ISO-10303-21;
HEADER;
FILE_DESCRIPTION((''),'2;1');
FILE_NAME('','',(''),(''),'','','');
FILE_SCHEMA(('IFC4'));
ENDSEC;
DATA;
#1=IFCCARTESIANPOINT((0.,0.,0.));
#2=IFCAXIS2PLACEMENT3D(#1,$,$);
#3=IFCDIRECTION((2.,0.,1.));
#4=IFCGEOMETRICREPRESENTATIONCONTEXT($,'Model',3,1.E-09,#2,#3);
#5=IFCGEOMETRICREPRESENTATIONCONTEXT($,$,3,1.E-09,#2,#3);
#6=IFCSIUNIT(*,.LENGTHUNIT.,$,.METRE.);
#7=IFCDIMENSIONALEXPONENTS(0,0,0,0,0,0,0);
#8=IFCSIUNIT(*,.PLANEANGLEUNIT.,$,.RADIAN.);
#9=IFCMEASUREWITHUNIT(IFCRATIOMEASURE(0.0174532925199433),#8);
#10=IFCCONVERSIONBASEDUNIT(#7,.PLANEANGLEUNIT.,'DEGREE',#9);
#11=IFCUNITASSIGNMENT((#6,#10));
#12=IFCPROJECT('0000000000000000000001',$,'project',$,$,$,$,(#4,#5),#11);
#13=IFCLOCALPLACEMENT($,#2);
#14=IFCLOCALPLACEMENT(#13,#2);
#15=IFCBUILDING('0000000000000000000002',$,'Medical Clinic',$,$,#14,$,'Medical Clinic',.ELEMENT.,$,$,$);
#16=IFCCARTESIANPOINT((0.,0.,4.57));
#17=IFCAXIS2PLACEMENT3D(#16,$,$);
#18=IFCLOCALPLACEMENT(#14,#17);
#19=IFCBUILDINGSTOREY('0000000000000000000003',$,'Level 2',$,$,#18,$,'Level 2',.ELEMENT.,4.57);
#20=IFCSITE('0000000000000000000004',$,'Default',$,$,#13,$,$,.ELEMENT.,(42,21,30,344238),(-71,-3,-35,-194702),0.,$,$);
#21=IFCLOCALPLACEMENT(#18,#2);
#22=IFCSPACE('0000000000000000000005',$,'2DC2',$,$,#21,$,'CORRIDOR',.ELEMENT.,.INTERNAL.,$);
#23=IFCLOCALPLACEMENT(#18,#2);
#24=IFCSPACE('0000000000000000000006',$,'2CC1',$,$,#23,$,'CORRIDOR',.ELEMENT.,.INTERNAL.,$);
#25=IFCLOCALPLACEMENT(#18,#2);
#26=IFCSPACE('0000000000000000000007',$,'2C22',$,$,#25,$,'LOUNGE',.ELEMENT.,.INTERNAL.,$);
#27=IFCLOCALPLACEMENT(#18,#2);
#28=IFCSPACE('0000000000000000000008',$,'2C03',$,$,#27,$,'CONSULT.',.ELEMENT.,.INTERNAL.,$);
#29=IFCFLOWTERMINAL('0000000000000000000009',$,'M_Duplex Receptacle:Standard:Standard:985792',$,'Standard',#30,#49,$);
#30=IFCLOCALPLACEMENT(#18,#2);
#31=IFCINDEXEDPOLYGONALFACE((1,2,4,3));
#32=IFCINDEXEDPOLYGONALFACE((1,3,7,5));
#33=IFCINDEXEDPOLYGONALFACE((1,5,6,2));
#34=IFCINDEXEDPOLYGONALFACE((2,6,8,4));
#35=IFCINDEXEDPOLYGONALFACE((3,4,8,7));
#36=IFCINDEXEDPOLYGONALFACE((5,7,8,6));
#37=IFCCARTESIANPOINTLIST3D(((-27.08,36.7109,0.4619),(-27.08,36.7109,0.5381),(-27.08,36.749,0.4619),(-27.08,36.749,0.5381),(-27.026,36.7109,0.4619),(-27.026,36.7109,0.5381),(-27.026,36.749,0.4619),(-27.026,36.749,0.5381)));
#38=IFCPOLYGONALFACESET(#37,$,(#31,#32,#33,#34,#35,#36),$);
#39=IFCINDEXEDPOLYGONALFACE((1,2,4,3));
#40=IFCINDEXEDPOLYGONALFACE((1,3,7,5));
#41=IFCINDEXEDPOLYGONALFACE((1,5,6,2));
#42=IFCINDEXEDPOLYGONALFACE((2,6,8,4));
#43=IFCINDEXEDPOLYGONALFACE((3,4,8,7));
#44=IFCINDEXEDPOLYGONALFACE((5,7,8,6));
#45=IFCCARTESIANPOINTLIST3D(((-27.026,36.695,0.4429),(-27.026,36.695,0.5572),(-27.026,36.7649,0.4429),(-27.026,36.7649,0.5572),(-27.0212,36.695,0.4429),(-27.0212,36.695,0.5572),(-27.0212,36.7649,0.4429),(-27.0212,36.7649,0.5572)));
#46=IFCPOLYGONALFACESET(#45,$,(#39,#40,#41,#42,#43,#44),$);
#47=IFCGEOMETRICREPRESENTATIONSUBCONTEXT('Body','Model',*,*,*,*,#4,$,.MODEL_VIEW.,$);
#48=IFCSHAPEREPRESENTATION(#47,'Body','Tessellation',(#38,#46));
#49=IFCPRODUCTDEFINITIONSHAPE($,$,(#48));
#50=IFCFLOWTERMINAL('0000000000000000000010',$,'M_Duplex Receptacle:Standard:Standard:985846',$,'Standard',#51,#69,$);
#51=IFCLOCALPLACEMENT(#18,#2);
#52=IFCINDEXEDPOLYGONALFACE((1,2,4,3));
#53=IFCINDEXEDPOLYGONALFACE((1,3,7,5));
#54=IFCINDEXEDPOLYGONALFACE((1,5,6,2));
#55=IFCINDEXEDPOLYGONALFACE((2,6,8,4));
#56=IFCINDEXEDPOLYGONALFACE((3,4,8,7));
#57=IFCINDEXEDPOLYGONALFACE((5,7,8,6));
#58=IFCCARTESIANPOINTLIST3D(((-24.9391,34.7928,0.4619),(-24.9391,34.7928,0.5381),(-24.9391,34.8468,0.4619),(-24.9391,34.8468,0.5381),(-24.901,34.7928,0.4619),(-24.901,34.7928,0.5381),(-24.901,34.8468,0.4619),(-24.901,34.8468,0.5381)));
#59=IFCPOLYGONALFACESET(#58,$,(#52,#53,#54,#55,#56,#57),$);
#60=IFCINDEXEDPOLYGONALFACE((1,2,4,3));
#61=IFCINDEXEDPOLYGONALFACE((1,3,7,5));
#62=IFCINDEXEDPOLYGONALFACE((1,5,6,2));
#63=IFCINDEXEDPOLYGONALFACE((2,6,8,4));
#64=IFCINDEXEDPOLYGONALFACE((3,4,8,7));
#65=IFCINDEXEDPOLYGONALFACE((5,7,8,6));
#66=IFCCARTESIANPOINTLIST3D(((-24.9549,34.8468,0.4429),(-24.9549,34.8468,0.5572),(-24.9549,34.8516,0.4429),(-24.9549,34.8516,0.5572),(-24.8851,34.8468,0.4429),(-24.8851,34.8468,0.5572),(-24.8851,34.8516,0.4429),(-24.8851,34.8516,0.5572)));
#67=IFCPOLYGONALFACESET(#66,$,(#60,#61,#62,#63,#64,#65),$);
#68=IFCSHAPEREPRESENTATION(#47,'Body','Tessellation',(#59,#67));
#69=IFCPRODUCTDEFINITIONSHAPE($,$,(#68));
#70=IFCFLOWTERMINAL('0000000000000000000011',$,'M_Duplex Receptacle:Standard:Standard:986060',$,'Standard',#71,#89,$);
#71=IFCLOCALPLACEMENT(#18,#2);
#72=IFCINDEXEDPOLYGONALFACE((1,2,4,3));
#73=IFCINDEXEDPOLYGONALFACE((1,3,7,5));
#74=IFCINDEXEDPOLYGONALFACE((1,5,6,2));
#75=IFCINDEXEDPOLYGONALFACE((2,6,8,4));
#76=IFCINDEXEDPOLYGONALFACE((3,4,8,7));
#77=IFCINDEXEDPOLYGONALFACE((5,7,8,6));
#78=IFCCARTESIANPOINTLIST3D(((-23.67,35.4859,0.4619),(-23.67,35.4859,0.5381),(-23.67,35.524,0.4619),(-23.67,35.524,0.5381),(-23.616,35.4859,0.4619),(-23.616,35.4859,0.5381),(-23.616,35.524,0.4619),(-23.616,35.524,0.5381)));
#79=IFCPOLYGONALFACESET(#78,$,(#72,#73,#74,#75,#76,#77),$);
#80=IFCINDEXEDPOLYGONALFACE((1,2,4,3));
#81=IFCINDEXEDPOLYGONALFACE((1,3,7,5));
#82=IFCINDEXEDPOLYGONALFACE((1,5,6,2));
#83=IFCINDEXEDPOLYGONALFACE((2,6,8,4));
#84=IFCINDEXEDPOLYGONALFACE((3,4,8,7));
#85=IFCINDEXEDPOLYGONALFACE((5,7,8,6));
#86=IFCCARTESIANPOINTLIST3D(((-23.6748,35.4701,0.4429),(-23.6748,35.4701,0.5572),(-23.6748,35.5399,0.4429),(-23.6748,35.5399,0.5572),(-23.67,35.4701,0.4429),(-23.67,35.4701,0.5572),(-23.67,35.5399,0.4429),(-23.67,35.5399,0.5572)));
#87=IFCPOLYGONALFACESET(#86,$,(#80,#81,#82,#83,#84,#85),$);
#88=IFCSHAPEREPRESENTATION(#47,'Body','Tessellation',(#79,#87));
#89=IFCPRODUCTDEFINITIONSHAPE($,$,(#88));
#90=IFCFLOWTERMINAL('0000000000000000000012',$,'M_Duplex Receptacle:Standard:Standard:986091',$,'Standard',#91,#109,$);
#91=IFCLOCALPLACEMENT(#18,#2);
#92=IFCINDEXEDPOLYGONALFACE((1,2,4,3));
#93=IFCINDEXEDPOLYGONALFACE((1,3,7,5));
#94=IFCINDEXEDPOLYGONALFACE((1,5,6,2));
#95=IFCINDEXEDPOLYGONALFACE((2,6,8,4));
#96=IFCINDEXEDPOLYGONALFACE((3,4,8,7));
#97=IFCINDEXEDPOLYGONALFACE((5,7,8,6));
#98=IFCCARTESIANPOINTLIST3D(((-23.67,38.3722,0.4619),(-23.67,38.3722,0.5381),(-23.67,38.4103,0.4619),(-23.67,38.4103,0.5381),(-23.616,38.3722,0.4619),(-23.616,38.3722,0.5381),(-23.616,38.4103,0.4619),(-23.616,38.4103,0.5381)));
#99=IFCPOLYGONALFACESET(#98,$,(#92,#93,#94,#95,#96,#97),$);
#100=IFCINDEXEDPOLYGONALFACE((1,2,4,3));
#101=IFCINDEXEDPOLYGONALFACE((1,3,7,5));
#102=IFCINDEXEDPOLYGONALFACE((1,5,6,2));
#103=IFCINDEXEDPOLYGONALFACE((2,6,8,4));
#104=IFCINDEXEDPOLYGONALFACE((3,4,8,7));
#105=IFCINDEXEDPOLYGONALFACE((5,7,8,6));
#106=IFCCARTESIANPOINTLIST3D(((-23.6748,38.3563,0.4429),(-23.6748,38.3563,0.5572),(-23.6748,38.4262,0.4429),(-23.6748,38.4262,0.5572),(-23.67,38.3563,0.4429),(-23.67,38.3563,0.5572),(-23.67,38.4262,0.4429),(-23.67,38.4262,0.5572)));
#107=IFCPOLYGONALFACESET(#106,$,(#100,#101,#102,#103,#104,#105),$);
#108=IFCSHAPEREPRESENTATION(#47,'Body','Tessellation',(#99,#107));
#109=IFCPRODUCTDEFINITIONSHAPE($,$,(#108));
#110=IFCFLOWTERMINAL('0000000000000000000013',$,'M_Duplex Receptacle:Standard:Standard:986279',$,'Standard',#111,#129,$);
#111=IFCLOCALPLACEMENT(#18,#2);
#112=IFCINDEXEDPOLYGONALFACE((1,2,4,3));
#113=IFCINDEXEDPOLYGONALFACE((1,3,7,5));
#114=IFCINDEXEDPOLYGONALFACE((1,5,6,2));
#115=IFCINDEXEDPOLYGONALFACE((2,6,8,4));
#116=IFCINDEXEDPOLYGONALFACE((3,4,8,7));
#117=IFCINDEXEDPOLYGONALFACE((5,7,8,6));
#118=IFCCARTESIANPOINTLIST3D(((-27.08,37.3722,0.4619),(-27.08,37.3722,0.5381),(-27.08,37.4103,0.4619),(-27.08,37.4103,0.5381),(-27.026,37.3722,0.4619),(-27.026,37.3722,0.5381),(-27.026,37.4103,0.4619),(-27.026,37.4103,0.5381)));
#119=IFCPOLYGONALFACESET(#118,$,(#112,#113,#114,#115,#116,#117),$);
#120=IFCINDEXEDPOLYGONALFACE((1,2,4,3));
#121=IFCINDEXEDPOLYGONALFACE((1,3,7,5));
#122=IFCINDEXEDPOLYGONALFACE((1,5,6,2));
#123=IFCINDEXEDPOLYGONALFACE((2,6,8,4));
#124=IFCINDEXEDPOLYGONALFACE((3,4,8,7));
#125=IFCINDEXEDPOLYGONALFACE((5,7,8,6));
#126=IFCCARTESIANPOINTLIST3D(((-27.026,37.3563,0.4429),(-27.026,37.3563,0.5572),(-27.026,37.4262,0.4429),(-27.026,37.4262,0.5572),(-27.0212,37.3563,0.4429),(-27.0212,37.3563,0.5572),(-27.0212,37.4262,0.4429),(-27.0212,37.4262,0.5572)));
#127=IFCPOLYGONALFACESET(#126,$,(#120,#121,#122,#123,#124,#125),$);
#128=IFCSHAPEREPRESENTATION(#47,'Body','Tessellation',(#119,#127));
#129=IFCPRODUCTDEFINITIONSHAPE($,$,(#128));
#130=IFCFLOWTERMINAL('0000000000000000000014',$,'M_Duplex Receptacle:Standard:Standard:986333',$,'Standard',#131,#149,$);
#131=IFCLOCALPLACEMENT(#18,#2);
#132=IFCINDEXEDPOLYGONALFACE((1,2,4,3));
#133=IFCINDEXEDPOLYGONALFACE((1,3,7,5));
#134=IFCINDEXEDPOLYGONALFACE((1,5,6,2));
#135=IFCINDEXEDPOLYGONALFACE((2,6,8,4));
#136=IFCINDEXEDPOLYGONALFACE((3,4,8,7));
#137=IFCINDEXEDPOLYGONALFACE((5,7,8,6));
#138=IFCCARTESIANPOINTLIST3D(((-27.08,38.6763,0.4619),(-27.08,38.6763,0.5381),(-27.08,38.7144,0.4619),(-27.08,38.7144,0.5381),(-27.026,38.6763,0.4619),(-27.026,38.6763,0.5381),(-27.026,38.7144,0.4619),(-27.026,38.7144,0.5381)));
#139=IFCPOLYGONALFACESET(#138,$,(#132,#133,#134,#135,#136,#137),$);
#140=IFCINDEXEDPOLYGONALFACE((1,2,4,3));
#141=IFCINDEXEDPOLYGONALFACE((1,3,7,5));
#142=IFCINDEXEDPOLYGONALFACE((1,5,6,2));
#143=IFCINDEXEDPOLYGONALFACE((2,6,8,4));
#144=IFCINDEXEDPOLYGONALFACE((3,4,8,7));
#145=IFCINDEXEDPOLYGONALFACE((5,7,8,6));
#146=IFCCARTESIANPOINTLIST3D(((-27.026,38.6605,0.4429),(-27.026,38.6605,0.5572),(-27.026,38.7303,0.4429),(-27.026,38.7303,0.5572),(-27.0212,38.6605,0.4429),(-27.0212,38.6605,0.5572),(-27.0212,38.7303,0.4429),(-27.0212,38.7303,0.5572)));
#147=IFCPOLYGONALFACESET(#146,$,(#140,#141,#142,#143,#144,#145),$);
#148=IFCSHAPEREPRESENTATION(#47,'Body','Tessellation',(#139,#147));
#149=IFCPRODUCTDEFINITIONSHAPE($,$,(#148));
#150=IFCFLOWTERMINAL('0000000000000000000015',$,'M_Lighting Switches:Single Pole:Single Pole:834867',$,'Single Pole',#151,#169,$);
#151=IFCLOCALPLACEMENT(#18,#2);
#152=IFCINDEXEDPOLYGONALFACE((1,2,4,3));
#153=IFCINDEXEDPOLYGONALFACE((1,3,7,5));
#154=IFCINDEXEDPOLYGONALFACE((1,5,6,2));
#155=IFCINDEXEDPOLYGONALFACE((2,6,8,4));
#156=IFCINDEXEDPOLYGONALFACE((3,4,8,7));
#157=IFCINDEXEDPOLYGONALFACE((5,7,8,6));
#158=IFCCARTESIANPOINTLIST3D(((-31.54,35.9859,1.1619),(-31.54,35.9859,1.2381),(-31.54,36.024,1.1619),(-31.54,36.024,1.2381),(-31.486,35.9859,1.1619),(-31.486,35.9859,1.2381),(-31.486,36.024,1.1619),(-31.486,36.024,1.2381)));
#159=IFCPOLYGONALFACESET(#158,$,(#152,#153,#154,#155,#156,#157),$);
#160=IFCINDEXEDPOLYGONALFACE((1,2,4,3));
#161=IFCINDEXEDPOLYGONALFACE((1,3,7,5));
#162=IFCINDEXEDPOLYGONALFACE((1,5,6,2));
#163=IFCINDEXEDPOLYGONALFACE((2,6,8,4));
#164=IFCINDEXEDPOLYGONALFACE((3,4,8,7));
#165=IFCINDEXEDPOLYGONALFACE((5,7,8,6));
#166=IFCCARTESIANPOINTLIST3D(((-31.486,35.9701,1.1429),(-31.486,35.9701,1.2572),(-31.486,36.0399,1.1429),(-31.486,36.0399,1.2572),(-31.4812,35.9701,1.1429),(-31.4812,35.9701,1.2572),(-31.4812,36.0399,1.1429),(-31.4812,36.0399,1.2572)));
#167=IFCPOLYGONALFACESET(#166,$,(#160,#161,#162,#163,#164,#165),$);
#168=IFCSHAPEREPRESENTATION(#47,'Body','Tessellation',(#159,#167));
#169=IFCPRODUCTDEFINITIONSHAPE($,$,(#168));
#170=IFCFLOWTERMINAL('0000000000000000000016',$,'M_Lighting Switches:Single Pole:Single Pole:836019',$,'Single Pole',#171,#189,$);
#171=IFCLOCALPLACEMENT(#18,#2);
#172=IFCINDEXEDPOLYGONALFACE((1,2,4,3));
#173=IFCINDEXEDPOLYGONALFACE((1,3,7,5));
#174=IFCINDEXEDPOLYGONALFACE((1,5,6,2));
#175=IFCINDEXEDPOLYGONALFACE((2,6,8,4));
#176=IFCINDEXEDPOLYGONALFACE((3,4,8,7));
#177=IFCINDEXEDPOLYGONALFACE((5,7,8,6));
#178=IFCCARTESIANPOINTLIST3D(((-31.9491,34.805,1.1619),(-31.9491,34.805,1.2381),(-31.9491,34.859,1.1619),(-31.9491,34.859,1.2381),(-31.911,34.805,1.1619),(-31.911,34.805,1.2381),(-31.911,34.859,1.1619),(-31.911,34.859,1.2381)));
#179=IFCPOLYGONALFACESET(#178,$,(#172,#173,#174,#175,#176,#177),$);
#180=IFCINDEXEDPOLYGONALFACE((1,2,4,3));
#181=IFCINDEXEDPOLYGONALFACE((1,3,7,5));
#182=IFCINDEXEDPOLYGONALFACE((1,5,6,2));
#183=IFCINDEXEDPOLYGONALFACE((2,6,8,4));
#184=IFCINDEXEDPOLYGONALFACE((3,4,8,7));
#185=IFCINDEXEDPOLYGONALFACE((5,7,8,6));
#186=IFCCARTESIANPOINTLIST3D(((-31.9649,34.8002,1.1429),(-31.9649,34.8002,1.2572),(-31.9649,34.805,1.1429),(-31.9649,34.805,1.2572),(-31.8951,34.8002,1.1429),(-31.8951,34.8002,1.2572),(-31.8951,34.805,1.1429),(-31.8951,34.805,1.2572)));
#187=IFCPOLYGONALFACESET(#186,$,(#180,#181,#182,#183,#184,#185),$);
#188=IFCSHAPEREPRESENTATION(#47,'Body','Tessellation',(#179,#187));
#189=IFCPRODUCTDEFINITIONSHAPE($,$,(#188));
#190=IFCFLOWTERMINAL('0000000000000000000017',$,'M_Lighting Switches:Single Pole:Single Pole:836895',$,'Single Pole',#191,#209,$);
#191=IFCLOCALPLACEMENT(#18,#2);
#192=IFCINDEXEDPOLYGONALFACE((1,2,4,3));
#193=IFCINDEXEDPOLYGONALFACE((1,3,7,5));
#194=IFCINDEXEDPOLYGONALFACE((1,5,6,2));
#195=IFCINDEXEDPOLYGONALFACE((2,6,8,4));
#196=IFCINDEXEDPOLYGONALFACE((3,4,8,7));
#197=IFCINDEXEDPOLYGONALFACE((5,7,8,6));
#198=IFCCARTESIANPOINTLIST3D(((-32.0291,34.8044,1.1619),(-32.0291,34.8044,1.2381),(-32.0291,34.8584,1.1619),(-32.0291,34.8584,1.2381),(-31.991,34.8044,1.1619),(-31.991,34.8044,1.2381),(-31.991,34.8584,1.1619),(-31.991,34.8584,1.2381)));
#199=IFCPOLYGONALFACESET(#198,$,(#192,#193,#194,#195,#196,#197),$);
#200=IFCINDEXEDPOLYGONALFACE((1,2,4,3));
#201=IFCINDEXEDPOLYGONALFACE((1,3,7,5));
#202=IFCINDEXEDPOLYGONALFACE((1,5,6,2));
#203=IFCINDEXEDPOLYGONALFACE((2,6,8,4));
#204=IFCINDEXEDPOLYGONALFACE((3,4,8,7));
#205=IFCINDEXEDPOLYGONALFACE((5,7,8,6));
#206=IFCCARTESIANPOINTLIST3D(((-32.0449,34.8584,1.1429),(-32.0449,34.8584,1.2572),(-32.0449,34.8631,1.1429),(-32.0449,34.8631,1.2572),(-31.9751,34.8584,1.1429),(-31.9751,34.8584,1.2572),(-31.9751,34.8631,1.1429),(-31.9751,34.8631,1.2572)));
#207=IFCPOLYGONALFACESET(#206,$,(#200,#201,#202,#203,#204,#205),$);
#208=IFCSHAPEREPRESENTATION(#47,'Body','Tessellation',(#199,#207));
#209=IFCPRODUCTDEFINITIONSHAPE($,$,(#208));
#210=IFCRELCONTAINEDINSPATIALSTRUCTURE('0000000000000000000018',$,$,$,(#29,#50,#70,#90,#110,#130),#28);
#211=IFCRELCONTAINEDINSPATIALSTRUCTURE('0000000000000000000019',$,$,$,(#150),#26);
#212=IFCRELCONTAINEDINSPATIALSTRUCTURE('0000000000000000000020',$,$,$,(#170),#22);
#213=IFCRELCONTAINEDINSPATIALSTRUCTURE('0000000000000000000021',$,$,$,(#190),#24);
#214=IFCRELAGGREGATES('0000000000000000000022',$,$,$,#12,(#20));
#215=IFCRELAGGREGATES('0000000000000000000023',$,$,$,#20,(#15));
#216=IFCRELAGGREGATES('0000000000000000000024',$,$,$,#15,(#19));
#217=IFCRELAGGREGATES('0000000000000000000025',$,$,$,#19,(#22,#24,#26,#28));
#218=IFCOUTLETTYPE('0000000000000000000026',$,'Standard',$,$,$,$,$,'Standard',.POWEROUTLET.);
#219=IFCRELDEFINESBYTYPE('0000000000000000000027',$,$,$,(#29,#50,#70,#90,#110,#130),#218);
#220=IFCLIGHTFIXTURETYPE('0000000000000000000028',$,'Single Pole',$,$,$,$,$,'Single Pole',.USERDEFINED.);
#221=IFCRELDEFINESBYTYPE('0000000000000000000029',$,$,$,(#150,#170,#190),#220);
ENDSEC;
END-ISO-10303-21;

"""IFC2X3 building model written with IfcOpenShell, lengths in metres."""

from ifc_helpers import new_model, entity, si_unit, converted_unit, direction, frame, frame_2d, origin, origin_2d_with_axis, place, context, subcontext, project, spatial, rectangle, extrude, source, transform, mapped, type_object, type_shapes, element, save


model = new_model("IFC2X3")

# Units and contexts
model_context = context("Model", 3, precision=1e-09, world=origin(), true_north=direction((2.0, 0.0, 1.0)))
context_of_model = context(None, 3, precision=1e-09, world=origin(), true_north=direction((2.0, 0.0, 1.0)))
body_context = subcontext(model_context, "Body", "Model", "MODEL_VIEW")
ifc_project = project(units=[si_unit("LENGTHUNIT", "METRE"), converted_unit("PLANEANGLEUNIT", "DEGREE", entity("IfcRatioMeasure", 0.0174532925199433), si_unit("PLANEANGLEUNIT", "RADIAN"), dimensions=[0, 0, 0, 0, 0, 0, 0])], contexts=[model_context, context_of_model])

# Site, building, storey, space
site_placement = place(None, origin())
site = spatial("IfcSite", under=ifc_project, at=site_placement, Name="Default", CompositionType="ELEMENT", RefLatitude=(42, 21, 30, 344238), RefLongitude=(-71, -3, -35, -194702), RefElevation=0.0)
building_placement = place(site_placement, origin())
building = spatial("IfcBuilding", under=site, at=building_placement, Name="Medical Clinic", LongName="Medical Clinic", CompositionType="ELEMENT")
storey_placement = place(building_placement, frame((0.0, 0.0, 4.57)))
storey = spatial("IfcBuildingStorey", under=building, at=storey_placement, Name="Level 2", LongName="Level 2", CompositionType="ELEMENT", Elevation=4.57)
space_1_placement = place(storey_placement, origin())
space_1 = spatial("IfcSpace", under=storey, at=space_1_placement, Name="2DC2", LongName="CORRIDOR", CompositionType="ELEMENT", InteriorOrExteriorSpace="INTERNAL")

# Shared definitions
outlet_type = type_object("IfcOutletType", Name="Standard", ElementType="Standard", PredefinedType="POWEROUTLET")
shared_shape_1 = source(origin(), body_context, "Body", "SweptSolid", [
    extrude(rectangle(XDim=0.0381, YDim=0.0762, at=origin_2d_with_axis()), frame((0.0, 0.0, -0.054), z_axis=(0.0, 0.0, 1.0), x_axis=(-1.0, 0.0, 0.0)), (0.0, 0.0, 1.0), 0.054),
    extrude(rectangle(XDim=0.0698, YDim=0.1143, at=frame_2d((0.0, 0.0), x_axis=(1.0, 0.0))), frame((0.0, 0.0, 0.0), z_axis=(0.0, 0.0, 1.0), x_axis=(-1.0, 0.0, 0.0)), (0.0, 0.0, 1.0), 0.0048),
])
type_shapes(outlet_type, [shared_shape_1])

# Shared definitions
space_2_placement = place(storey_placement, origin())
space_2 = spatial("IfcSpace", under=storey, at=space_2_placement, Name="2CC1", LongName="CORRIDOR", CompositionType="ELEMENT", InteriorOrExteriorSpace="INTERNAL")

# Shared definitions
space_3_placement = place(storey_placement, origin())
space_3 = spatial("IfcSpace", under=storey, at=space_3_placement, Name="2C22", LongName="LOUNGE", CompositionType="ELEMENT", InteriorOrExteriorSpace="INTERNAL")

# Shared definitions
space_4_placement = place(storey_placement, origin())
space_4 = spatial("IfcSpace", under=storey, at=space_4_placement, Name="2C03", LongName="CONSULT.", CompositionType="ELEMENT", InteriorOrExteriorSpace="INTERNAL")

# Flow terminals
for number, where, z_axis, x_axis, name in (
    (1, (-27.026, 36.7299, 0.5), (1.0, 0.0, 0.0), (0.0, 1.0, 0.0), "M_Duplex Receptacle:Standard:Standard:985792"),
    (2, (-24.92, 34.8468, 0.5), (0.0, 1.0, 0.0), (-1.0, 0.0, 0.0), "M_Duplex Receptacle:Standard:Standard:985846"),
    (3, (-23.67, 35.505, 0.5), (-1.0, 0.0, 0.0), (0.0, -1.0, 0.0), "M_Duplex Receptacle:Standard:Standard:986060"),
    (4, (-23.67, 38.3912, 0.5), (-1.0, 0.0, 0.0), (0.0, -1.0, 0.0), "M_Duplex Receptacle:Standard:Standard:986091"),
    (5, (-27.026, 37.3912, 0.5), (1.0, 0.0, 0.0), (0.0, 1.0, 0.0), "M_Duplex Receptacle:Standard:Standard:986279"),
    (6, (-27.026, 38.6954, 0.5), (1.0, 0.0, 0.0), (0.0, 1.0, 0.0), "M_Duplex Receptacle:Standard:Standard:986333"),
):
    element("IfcFlowTerminal", number, at=place(space_4_placement, frame(where, z_axis=z_axis, x_axis=x_axis)), inside=space_4, type_object=outlet_type, Name=name, ObjectType="Standard", context=body_context, shape_type="MappedRepresentation", body=[
        mapped(shared_shape_1, transform((0.0, 0.0, 0.0), scale=1.0)),
    ])
light_fixture_type_1 = type_object("IfcLightFixtureType", Name="Single Pole", ElementType="Single Pole", PredefinedType="USERDEFINED")
shared_shape_2 = source(origin(), body_context, "Body", "SweptSolid", [
    extrude(rectangle(XDim=0.0381, YDim=0.0762, at=origin_2d_with_axis()), frame((0.0, 0.0, -0.054), z_axis=(0.0, 0.0, 1.0), x_axis=(-1.0, 0.0, 0.0)), (0.0, 0.0, 1.0), 0.054),
    extrude(rectangle(XDim=0.0698, YDim=0.1143, at=frame_2d((0.0, 0.0), x_axis=(1.0, 0.0))), frame((0.0, 0.0, 0.0), z_axis=(0.0, 0.0, 1.0), x_axis=(-1.0, 0.0, 0.0)), (0.0, 0.0, 1.0), 0.0048),
])
type_shapes(light_fixture_type_1, [shared_shape_2])
flow_terminal_1_placement = place(space_3_placement, frame((-31.486, 36.005, 1.2), z_axis=(1.0, 0.0, 0.0), x_axis=(0.0, 1.0, 0.0)))
element("IfcFlowTerminal", 7, at=flow_terminal_1_placement, inside=space_3, type_object=light_fixture_type_1, Name="M_Lighting Switches:Single Pole:Single Pole:834867", ObjectType="Single Pole", context=body_context, shape_type="MappedRepresentation", body=[
    mapped(shared_shape_2, transform((0.0, 0.0, 0.0), scale=1.0)),
])
flow_terminal_2_placement = place(space_1_placement, frame((-31.93, 34.805, 1.2), z_axis=(0.0, -1.0, 0.0), x_axis=(1.0, 0.0, 0.0)))
element("IfcFlowTerminal", 8, at=flow_terminal_2_placement, inside=space_1, type_object=light_fixture_type_1, Name="M_Lighting Switches:Single Pole:Single Pole:836019", ObjectType="Single Pole", context=body_context, shape_type="MappedRepresentation", body=[
    mapped(shared_shape_2, transform((0.0, 0.0, 0.0), scale=1.0)),
])
flow_terminal_3_placement = place(space_2_placement, frame((-32.01, 34.8584, 1.2), z_axis=(0.0, 1.0, 0.0), x_axis=(-1.0, 0.0, 0.0)))
element("IfcFlowTerminal", 9, at=flow_terminal_3_placement, inside=space_2, type_object=light_fixture_type_1, Name="M_Lighting Switches:Single Pole:Single Pole:836895", ObjectType="Single Pole", context=body_context, shape_type="MappedRepresentation", body=[
    mapped(shared_shape_2, transform((0.0, 0.0, 0.0), scale=1.0)),
])

save(model, "model.ifc")
